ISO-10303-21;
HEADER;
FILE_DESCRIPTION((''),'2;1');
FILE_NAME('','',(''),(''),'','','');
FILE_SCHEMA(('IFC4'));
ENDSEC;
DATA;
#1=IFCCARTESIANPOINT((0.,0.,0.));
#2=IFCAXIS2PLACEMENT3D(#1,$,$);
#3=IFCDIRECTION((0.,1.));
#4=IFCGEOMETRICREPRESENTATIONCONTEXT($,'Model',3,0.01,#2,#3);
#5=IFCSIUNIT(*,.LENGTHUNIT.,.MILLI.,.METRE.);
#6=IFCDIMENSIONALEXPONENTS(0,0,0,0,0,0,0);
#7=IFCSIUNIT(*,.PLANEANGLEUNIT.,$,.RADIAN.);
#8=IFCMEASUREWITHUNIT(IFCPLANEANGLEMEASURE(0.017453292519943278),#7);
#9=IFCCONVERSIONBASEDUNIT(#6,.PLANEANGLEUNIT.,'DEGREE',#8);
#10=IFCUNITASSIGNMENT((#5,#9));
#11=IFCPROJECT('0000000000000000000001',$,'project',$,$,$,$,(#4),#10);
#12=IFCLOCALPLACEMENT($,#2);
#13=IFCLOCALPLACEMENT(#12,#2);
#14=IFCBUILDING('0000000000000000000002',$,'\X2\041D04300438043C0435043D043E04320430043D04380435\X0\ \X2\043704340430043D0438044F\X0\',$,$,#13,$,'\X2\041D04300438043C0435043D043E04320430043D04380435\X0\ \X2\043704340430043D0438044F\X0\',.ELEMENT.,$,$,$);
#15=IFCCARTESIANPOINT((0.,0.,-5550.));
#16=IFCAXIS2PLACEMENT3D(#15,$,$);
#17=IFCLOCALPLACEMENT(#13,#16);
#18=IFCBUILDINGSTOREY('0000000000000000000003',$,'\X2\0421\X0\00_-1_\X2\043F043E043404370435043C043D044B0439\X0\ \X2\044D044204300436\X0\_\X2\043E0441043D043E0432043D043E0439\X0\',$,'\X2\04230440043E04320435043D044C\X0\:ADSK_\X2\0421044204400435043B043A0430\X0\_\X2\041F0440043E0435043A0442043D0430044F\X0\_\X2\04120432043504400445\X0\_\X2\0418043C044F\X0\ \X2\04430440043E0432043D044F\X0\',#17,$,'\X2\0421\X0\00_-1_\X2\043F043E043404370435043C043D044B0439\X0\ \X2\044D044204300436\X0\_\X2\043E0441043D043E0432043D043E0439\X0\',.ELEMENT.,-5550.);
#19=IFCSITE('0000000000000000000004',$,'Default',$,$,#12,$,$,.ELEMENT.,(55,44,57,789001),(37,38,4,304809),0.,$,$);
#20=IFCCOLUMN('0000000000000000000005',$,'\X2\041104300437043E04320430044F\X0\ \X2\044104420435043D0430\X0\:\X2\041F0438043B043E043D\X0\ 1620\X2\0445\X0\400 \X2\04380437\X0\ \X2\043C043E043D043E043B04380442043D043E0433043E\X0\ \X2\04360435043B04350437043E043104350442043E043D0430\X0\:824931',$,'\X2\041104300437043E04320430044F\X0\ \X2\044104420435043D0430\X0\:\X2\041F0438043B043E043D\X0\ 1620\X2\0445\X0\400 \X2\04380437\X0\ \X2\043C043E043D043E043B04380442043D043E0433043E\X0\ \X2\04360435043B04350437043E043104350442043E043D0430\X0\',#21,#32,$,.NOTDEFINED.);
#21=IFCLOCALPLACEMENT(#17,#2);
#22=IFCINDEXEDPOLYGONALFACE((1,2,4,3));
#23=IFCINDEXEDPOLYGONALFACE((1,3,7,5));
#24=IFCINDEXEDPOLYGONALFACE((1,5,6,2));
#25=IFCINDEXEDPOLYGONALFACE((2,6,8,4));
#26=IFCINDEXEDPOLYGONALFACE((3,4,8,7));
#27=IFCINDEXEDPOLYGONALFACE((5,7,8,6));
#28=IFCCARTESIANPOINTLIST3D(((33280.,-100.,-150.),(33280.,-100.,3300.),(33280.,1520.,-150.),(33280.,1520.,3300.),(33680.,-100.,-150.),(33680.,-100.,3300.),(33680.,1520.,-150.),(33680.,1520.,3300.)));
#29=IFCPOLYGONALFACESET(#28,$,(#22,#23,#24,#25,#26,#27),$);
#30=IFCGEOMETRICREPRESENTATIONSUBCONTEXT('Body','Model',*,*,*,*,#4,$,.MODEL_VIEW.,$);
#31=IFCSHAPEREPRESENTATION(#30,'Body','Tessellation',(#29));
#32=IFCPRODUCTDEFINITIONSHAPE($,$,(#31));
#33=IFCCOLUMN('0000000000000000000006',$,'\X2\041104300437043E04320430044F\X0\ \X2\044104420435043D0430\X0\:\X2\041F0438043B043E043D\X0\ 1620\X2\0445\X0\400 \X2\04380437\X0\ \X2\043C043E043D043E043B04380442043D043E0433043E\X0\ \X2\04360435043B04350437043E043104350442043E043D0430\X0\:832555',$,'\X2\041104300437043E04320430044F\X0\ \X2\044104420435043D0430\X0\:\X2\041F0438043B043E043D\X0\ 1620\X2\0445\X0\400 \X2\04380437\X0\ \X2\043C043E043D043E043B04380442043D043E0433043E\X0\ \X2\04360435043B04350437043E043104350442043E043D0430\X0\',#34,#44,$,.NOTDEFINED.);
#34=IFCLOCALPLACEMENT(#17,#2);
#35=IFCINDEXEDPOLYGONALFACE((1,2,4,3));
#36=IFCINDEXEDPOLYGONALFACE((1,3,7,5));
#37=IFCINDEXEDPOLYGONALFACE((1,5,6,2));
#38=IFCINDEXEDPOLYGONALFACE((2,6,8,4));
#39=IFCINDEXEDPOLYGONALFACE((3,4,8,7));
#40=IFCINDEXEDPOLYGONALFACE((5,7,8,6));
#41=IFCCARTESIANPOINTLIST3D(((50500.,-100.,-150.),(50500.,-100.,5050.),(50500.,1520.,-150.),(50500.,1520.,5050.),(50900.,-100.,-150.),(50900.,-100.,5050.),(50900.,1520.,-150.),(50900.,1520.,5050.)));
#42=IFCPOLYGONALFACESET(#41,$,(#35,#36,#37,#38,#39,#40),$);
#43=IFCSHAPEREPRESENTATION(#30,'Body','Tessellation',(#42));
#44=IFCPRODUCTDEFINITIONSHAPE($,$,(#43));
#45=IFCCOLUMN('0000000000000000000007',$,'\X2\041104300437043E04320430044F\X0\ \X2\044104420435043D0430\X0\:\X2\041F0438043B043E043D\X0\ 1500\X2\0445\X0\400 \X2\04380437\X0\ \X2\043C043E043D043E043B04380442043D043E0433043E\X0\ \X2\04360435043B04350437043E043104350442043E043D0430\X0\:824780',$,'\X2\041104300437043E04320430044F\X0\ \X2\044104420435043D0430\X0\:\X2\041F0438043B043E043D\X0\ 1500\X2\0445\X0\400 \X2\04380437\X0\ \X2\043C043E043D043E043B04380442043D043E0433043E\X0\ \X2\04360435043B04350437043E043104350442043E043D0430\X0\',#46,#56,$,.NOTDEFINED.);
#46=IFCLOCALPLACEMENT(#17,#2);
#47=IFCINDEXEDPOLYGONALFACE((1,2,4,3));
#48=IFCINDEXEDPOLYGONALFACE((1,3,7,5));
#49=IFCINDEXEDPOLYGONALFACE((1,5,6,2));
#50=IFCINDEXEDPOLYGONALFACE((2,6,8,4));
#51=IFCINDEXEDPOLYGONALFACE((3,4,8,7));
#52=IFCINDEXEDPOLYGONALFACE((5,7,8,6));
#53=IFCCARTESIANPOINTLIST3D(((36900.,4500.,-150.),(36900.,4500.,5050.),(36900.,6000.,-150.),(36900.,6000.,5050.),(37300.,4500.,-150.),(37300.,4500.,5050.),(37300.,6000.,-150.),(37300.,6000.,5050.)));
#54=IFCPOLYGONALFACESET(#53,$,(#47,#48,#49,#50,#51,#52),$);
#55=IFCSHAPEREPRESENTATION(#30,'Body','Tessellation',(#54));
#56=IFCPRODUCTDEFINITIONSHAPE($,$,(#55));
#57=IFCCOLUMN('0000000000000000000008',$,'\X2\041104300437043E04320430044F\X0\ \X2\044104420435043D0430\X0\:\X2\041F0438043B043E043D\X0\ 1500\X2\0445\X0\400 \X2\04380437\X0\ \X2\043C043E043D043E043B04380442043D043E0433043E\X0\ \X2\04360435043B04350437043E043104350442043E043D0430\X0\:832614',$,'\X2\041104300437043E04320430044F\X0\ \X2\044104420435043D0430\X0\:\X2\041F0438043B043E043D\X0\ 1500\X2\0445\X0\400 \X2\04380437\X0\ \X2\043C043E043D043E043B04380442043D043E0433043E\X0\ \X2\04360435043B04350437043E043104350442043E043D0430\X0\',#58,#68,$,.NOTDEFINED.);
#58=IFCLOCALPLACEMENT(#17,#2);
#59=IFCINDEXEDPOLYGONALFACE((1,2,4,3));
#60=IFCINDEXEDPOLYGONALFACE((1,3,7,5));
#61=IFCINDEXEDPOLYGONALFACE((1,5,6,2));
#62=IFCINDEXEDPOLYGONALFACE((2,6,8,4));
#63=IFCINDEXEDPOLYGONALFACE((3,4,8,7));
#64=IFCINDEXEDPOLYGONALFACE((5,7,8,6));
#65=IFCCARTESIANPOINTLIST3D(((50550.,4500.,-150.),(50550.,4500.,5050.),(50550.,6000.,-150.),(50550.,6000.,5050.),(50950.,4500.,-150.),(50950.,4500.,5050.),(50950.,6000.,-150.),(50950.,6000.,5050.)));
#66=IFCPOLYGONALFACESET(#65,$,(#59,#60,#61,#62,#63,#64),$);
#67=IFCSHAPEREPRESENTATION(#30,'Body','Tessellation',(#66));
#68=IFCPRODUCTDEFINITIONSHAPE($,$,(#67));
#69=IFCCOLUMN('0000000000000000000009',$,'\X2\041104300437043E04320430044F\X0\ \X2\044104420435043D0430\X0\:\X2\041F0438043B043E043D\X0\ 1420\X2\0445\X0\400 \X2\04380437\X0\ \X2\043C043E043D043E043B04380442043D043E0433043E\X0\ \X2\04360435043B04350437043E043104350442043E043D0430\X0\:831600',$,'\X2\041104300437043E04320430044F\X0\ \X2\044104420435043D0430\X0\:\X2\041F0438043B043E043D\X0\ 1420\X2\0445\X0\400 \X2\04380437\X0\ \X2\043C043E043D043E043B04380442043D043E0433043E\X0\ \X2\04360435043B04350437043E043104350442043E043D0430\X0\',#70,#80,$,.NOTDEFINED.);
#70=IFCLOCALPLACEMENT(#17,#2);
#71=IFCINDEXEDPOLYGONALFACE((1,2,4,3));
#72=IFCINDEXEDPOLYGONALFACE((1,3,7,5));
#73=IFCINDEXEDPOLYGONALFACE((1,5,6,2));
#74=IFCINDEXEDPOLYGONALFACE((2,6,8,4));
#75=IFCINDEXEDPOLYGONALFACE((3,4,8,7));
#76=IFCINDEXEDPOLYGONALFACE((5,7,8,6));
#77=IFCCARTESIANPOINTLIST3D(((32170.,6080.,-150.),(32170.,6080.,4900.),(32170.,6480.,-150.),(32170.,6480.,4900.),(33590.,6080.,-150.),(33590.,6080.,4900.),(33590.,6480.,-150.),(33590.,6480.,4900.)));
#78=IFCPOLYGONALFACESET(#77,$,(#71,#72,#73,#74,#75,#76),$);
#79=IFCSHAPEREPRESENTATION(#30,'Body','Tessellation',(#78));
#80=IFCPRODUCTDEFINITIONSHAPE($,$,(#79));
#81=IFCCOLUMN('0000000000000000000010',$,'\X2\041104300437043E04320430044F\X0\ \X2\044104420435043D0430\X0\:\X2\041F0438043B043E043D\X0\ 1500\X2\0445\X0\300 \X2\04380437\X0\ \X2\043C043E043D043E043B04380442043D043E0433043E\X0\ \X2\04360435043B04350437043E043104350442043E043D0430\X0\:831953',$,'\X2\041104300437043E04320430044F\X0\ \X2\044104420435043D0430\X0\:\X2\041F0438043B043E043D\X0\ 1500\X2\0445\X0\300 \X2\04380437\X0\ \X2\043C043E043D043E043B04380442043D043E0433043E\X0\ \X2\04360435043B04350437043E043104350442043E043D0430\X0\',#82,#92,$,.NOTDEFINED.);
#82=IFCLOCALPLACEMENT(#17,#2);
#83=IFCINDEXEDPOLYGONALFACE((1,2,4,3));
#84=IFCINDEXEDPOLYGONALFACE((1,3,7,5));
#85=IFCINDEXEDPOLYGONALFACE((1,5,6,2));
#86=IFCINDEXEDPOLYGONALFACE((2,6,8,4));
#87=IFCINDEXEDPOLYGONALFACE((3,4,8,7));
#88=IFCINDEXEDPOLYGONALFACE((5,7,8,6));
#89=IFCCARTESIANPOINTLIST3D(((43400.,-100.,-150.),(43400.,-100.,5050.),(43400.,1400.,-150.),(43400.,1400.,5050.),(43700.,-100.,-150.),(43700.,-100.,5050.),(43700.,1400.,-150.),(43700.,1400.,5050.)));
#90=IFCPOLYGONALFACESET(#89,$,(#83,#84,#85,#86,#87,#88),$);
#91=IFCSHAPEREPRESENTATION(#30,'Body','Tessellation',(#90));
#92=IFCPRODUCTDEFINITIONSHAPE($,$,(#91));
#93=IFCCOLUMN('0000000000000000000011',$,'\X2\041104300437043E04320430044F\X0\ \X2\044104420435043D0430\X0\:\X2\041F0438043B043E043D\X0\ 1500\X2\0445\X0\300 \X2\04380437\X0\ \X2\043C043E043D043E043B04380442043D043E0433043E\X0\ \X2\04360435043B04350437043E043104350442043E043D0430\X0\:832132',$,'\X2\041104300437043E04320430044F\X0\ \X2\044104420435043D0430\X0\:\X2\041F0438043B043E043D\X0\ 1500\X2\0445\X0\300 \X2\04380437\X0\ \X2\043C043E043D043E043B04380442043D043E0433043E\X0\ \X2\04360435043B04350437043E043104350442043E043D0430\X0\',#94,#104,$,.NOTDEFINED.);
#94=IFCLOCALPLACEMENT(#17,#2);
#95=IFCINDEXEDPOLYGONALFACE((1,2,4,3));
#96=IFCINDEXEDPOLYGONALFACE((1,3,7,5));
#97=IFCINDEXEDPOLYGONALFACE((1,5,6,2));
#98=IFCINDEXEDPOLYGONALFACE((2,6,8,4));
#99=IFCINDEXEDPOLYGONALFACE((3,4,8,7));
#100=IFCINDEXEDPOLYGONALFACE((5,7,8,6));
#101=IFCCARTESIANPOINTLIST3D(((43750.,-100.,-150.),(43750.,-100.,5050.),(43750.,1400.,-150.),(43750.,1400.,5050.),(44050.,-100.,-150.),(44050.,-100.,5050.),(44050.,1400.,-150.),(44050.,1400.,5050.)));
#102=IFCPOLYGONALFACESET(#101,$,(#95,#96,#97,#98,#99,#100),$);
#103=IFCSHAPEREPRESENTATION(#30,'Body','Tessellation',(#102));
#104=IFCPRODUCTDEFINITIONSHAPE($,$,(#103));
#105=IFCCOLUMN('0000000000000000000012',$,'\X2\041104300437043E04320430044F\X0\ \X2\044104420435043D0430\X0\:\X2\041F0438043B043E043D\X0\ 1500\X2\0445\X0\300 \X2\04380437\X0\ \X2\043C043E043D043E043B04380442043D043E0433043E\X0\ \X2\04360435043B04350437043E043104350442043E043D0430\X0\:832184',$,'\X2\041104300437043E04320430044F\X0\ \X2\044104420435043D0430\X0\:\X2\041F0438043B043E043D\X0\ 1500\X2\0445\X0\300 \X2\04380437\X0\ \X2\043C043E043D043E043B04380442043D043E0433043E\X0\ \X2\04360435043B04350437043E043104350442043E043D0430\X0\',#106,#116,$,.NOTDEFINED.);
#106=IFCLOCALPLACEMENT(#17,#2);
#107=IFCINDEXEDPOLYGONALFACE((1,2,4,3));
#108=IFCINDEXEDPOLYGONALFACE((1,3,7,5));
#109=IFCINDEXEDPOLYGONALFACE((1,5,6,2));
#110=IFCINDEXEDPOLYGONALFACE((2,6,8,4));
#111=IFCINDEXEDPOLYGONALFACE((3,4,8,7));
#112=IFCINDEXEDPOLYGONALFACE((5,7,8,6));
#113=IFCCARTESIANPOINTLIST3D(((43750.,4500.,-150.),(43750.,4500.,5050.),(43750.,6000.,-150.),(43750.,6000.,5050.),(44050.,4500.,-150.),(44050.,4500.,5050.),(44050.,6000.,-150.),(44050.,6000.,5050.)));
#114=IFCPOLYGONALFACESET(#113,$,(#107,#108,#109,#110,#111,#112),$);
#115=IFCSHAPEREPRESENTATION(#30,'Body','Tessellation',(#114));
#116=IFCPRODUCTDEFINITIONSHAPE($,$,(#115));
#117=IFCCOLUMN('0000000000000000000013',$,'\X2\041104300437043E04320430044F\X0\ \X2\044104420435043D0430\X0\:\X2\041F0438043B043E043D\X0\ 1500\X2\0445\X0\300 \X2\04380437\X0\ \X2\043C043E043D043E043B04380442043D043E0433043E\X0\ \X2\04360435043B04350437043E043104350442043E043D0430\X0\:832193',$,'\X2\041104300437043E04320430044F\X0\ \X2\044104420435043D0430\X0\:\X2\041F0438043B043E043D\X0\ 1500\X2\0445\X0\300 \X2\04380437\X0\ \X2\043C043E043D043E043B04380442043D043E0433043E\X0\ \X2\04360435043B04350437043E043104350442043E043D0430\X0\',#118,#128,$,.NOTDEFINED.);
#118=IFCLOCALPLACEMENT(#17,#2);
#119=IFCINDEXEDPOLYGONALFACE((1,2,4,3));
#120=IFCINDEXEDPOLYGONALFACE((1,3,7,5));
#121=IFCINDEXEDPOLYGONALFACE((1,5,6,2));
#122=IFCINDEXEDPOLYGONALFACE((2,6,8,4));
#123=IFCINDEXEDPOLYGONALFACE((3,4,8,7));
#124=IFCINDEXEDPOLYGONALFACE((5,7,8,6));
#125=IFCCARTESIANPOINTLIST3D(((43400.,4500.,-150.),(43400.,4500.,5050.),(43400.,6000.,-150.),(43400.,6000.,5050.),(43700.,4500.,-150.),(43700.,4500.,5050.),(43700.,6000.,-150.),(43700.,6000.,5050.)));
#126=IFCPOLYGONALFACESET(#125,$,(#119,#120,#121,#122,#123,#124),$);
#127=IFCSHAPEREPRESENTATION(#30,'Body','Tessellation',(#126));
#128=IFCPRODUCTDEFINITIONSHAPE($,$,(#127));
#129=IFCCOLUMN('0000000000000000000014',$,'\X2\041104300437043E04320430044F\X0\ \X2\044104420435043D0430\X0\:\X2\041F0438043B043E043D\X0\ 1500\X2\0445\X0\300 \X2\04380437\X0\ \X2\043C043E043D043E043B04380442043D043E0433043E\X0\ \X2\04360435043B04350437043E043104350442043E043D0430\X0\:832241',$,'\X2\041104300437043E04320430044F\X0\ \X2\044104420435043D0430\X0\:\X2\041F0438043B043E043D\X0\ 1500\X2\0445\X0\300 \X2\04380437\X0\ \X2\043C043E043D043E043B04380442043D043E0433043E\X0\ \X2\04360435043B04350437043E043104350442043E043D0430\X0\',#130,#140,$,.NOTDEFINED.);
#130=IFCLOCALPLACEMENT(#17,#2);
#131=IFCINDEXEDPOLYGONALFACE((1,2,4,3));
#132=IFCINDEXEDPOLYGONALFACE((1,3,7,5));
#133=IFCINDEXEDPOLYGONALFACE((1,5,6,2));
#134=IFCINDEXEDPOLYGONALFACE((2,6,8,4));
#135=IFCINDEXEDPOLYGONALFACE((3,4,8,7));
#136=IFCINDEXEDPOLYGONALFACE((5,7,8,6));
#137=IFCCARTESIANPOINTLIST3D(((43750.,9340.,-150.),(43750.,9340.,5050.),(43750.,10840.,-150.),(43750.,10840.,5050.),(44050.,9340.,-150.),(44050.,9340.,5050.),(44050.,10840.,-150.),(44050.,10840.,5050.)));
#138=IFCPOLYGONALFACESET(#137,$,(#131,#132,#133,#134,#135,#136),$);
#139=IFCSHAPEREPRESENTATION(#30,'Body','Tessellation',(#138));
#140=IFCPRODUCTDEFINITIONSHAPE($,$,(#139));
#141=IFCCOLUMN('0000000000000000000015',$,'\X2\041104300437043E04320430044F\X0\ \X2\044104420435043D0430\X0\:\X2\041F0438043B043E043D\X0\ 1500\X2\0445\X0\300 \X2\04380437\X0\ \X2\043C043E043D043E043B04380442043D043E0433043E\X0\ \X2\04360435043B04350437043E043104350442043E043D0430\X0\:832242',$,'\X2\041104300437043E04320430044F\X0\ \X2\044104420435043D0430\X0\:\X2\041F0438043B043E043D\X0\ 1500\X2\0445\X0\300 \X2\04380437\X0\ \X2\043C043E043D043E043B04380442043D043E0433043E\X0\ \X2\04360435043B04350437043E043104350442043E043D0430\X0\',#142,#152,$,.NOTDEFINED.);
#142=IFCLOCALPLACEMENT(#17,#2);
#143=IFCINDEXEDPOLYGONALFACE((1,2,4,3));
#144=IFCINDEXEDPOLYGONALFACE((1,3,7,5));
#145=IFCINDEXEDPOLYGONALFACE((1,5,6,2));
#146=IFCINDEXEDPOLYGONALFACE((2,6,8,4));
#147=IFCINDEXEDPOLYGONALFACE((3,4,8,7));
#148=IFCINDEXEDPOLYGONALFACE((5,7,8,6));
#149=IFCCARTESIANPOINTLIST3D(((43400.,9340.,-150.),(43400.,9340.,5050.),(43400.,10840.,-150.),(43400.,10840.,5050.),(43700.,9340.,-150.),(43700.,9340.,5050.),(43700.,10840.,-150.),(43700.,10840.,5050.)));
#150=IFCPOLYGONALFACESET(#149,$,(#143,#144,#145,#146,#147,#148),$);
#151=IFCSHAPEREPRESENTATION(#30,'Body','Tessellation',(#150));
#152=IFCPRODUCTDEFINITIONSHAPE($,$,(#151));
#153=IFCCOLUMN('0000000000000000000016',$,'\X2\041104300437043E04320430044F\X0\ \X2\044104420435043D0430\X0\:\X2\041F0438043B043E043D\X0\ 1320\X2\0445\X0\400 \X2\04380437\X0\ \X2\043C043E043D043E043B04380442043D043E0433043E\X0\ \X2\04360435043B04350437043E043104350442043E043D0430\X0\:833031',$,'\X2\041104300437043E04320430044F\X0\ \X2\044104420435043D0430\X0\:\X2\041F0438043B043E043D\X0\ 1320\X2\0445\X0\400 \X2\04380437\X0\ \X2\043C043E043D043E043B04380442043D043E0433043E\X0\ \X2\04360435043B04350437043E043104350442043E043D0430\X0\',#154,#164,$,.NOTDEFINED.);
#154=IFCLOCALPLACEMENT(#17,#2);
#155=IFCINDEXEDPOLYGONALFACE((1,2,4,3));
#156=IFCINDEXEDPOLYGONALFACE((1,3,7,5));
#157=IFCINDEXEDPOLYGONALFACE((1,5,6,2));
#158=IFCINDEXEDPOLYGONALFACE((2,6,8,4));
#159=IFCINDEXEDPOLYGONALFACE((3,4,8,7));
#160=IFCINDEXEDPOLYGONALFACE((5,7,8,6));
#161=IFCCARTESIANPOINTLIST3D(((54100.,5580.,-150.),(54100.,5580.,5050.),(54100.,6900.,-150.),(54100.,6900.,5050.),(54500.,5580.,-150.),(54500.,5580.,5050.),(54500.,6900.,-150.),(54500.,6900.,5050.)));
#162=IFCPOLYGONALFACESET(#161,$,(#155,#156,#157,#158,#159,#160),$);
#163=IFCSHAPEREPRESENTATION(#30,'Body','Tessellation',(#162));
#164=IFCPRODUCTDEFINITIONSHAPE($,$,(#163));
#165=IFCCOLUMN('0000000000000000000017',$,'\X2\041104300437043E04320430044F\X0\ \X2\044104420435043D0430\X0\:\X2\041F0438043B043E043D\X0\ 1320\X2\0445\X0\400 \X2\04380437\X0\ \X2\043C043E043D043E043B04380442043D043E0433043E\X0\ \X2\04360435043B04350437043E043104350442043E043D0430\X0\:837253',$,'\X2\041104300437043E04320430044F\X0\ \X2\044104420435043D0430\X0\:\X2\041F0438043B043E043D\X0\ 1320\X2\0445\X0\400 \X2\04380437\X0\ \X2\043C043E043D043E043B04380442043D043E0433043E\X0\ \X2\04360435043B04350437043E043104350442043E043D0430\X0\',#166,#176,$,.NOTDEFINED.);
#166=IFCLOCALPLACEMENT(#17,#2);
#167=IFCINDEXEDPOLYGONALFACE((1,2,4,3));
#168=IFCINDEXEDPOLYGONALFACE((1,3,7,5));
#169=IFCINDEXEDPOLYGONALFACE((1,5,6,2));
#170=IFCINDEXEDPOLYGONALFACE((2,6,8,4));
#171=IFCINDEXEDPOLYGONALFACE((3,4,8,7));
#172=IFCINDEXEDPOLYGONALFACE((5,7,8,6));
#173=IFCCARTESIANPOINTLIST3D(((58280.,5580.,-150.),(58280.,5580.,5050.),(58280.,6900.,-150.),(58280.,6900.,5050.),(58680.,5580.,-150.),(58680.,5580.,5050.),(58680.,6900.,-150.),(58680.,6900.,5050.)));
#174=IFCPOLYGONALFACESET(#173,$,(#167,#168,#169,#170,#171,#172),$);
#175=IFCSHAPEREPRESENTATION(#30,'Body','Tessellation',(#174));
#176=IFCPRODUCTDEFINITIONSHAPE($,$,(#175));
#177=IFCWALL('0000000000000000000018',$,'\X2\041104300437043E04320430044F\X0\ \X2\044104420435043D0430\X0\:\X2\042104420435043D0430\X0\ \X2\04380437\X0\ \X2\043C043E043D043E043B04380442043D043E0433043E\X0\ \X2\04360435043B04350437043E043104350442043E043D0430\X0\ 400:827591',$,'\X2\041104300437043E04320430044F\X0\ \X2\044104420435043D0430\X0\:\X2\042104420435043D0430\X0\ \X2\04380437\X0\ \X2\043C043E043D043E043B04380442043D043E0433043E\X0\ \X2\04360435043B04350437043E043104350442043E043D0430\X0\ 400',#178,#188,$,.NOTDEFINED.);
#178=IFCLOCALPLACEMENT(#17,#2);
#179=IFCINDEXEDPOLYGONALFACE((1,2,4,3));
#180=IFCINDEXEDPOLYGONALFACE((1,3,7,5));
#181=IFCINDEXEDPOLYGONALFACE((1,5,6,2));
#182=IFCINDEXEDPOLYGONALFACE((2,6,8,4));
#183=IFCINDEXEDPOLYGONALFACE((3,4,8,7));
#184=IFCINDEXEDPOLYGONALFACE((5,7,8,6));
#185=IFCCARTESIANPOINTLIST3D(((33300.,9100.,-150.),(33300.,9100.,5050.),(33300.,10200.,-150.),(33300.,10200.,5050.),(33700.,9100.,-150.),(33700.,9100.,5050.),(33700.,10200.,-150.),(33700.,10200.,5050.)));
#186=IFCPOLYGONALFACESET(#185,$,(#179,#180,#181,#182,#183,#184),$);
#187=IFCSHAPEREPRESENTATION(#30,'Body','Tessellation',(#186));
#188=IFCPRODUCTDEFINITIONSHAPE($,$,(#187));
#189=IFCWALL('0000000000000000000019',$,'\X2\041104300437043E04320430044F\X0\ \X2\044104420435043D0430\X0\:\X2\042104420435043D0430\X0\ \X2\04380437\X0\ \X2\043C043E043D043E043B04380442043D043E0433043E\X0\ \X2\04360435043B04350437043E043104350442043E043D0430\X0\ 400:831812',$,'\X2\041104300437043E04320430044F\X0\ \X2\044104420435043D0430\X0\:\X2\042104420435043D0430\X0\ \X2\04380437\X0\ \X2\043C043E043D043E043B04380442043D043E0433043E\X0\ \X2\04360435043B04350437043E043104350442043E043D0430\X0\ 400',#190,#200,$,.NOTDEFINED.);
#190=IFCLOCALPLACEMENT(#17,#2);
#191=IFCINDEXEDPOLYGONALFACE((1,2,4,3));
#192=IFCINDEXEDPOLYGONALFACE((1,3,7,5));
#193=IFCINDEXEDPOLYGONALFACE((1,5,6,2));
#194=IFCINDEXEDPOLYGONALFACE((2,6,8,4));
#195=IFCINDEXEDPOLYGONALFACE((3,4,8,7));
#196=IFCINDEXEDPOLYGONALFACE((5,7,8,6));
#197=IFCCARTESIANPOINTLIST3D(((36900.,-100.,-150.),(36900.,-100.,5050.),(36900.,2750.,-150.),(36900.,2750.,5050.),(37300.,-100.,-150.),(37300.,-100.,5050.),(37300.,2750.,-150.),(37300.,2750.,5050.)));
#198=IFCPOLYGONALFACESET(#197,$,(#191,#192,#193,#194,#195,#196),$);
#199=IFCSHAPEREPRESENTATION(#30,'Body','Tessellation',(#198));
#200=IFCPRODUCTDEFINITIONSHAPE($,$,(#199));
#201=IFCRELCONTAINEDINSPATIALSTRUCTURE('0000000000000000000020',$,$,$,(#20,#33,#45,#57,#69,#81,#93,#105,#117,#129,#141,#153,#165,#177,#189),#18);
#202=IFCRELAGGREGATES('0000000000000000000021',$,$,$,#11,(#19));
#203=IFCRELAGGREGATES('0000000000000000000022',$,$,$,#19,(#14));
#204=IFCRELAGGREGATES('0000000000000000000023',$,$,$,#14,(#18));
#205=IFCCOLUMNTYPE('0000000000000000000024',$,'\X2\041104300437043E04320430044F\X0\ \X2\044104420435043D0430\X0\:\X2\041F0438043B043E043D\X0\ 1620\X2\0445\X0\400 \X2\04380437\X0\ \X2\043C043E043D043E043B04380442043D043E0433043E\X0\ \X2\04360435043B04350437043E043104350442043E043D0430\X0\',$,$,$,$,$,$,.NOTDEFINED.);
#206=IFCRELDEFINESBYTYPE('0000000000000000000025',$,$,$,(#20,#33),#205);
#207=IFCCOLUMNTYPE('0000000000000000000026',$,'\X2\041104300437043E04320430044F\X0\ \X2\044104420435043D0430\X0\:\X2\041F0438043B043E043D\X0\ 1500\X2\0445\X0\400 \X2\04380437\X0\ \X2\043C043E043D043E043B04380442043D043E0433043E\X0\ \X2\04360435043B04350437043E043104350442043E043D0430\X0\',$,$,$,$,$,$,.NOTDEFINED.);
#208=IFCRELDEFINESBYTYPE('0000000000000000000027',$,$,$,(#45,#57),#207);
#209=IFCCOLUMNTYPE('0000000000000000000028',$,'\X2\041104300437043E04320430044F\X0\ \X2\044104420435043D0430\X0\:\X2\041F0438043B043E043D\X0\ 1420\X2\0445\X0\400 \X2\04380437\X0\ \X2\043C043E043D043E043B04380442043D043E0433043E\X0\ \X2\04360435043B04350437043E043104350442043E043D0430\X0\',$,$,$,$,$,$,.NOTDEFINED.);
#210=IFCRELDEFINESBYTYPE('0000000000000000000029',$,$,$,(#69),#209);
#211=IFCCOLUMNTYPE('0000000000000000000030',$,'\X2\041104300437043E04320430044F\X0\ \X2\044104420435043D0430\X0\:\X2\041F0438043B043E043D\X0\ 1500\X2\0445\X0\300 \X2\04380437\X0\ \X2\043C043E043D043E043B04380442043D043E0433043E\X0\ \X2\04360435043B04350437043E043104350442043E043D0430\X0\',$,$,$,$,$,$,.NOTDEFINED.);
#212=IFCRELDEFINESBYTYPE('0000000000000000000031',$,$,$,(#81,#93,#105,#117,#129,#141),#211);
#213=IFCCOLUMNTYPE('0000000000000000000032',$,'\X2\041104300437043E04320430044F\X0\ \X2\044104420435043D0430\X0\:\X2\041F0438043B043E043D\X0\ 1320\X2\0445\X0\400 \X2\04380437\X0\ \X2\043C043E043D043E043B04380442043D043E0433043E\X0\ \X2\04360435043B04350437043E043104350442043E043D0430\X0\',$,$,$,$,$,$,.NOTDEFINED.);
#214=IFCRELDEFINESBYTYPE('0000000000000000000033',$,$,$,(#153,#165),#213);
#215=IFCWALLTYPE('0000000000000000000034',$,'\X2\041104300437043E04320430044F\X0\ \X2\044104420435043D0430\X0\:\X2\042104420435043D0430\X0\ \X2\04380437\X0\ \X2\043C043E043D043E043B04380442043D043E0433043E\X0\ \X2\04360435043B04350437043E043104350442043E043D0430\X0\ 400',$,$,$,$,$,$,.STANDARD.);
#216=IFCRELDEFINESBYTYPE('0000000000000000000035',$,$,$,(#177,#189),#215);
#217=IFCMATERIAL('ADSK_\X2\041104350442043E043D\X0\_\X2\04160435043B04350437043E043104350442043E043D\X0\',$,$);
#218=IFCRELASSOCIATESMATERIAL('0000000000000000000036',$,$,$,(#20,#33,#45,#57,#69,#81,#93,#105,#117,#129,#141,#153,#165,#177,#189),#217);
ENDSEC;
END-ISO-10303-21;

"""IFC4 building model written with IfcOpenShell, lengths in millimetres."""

from ifc_helpers import new_model, entity, si_unit, converted_unit, direction, frame, origin, place, context, subcontext, project, spatial, indexed_curve, outline, extrude, material, type_object, element, save


model = new_model("IFC4")

# Units and contexts
model_context = context("Model", 3, precision=0.01, world=origin(), true_north=direction((0.0, 1.0)))
body_context = subcontext(model_context, "Body", "Model", "MODEL_VIEW")
ifc_project = project(units=[si_unit("LENGTHUNIT", "METRE", prefix="MILLI"), converted_unit("PLANEANGLEUNIT", "DEGREE", entity("IfcPlaneAngleMeasure", 0.017453292519943278), si_unit("PLANEANGLEUNIT", "RADIAN"), dimensions=[0, 0, 0, 0, 0, 0, 0])], contexts=[model_context])

# Site, building, storey
site_placement = place(None, origin())
site = spatial("IfcSite", under=ifc_project, at=site_placement, Name="Default", CompositionType="ELEMENT", RefLatitude=(55, 44, 57, 789001), RefLongitude=(37, 38, 4, 304809), RefElevation=0.0)
building_placement = place(site_placement, origin())
building = spatial("IfcBuilding", under=site, at=building_placement, Name="Наименование здания", LongName="Наименование здания", CompositionType="ELEMENT")
storey_placement = place(building_placement, frame((0.0, 0.0, -5550.0)))
storey = spatial("IfcBuildingStorey", under=building, at=storey_placement, Name="С00_-1_подземный этаж_основной", ObjectType="Уровень:ADSK_Стрелка_Проектная_Вверх_Имя уровня", LongName="С00_-1_подземный этаж_основной", CompositionType="ELEMENT", Elevation=-5550.0)

# Columns
ifc_material_1 = material(Name="ADSK_Бетон_Железобетон")
column_type_1 = type_object("IfcColumnType", Name="Базовая стена:Пилон 1620х400 из монолитного железобетона", PredefinedType="NOTDEFINED")
column_1_placement = place(storey_placement, frame((33480.0, -100.0, -150.0), z_axis=(0.0, 0.0, 1.0), x_axis=(0.0, 1.0, 0.0)))
element("IfcColumn", 1, at=column_1_placement, inside=storey, type_object=column_type_1, material=ifc_material_1, Name="Базовая стена:Пилон 1620х400 из монолитного железобетона:824931", ObjectType="Базовая стена:Пилон 1620х400 из монолитного железобетона", PredefinedType="NOTDEFINED", context=body_context, shape_type="SweptSolid", body=[
    extrude(outline(indexed_curve([(1620.0, 200.0), (0.0, 200.0), (0.0, -200.0), (1620.0, -200.0), (1620.0, 200.0)], self_intersect=False)), origin(), (0.0, 0.0, 1.0), 3450.0),
])
column_2_placement = place(storey_placement, frame((50700.0, -100.0, -150.0), z_axis=(0.0, 0.0, 1.0), x_axis=(0.0, 1.0, 0.0)))
element("IfcColumn", 2, at=column_2_placement, inside=storey, type_object=column_type_1, material=ifc_material_1, Name="Базовая стена:Пилон 1620х400 из монолитного железобетона:832555", ObjectType="Базовая стена:Пилон 1620х400 из монолитного железобетона", PredefinedType="NOTDEFINED", context=body_context, shape_type="SweptSolid", body=[
    extrude(outline(indexed_curve([(1620.0, 200.0), (0.0, 200.0), (0.0, -200.0), (1620.0, -200.0), (1620.0, 200.0)], self_intersect=False)), origin(), (0.0, 0.0, 1.0), 5200.0),
])
column_type_2 = type_object("IfcColumnType", Name="Базовая стена:Пилон 1500х400 из монолитного железобетона", PredefinedType="NOTDEFINED")
column_3_placement = place(storey_placement, frame((37100.0, 4500.0, -150.0), z_axis=(0.0, 0.0, 1.0), x_axis=(0.0, 1.0, 0.0)))
element("IfcColumn", 3, at=column_3_placement, inside=storey, type_object=column_type_2, material=ifc_material_1, Name="Базовая стена:Пилон 1500х400 из монолитного железобетона:824780", ObjectType="Базовая стена:Пилон 1500х400 из монолитного железобетона", PredefinedType="NOTDEFINED", context=body_context, shape_type="SweptSolid", body=[
    extrude(outline(indexed_curve([(1500.0, 200.0), (0.0, 200.0), (0.0, -200.0), (1500.0, -200.0), (1500.0, 200.0)], self_intersect=False)), origin(), (0.0, 0.0, 1.0), 5200.0),
])
column_4_placement = place(storey_placement, frame((50750.0, 4500.0, -150.0), z_axis=(0.0, 0.0, 1.0), x_axis=(0.0, 1.0, 0.0)))
element("IfcColumn", 4, at=column_4_placement, inside=storey, type_object=column_type_2, material=ifc_material_1, Name="Базовая стена:Пилон 1500х400 из монолитного железобетона:832614", ObjectType="Базовая стена:Пилон 1500х400 из монолитного железобетона", PredefinedType="NOTDEFINED", context=body_context, shape_type="SweptSolid", body=[
    extrude(outline(indexed_curve([(1500.0, 200.0), (0.0, 200.0), (0.0, -200.0), (1500.0, -200.0), (1500.0, 200.0)], self_intersect=False)), origin(), (0.0, 0.0, 1.0), 5200.0),
])
column_type_3 = type_object("IfcColumnType", Name="Базовая стена:Пилон 1420х400 из монолитного железобетона", PredefinedType="NOTDEFINED")
column_5_placement = place(storey_placement, frame((32170.0, 6280.0, -150.0)))
element("IfcColumn", 5, at=column_5_placement, inside=storey, type_object=column_type_3, material=ifc_material_1, Name="Базовая стена:Пилон 1420х400 из монолитного железобетона:831600", ObjectType="Базовая стена:Пилон 1420х400 из монолитного железобетона", PredefinedType="NOTDEFINED", context=body_context, shape_type="SweptSolid", body=[
    extrude(outline(indexed_curve([(1420.0, 200.0), (0.0, 200.0), (0.0, -200.0), (1420.0, -200.0), (1420.0, 200.0)], self_intersect=False)), origin(), (0.0, 0.0, 1.0), 5050.0),
])
column_type_4 = type_object("IfcColumnType", Name="Базовая стена:Пилон 1500х300 из монолитного железобетона", PredefinedType="NOTDEFINED")
for number, where, z_axis, x_axis, name in (
    (6, (43550.0, -100.0, -150.0), (0.0, 0.0, 1.0), (0.0, 1.0, 0.0), "Базовая стена:Пилон 1500х300 из монолитного железобетона:831953"),
    (7, (43900.0, -100.0, -150.0), (0.0, 0.0, 1.0), (0.0, 1.0, 0.0), "Базовая стена:Пилон 1500х300 из монолитного железобетона:832132"),
    (8, (43900.0, 4500.0, -150.0), (0.0, 0.0, 1.0), (0.0, 1.0, 0.0), "Базовая стена:Пилон 1500х300 из монолитного железобетона:832184"),
    (9, (43550.0, 4500.0, -150.0), (0.0, 0.0, 1.0), (0.0, 1.0, 0.0), "Базовая стена:Пилон 1500х300 из монолитного железобетона:832193"),
    (10, (43900.0, 9340.0, -150.0), (0.0, 0.0, 1.0), (0.0, 1.0, 0.0), "Базовая стена:Пилон 1500х300 из монолитного железобетона:832241"),
):
    element("IfcColumn", number, at=place(storey_placement, frame(where, z_axis=z_axis, x_axis=x_axis)), inside=storey, type_object=column_type_4, material=ifc_material_1, Name=name, ObjectType="Базовая стена:Пилон 1500х300 из монолитного железобетона", PredefinedType="NOTDEFINED", context=body_context, shape_type="SweptSolid", body=[
        extrude(outline(indexed_curve([(1500.0, 150.0), (0.0, 150.0), (0.0, -150.0), (1500.0, -150.0), (1500.0, 150.0)], self_intersect=False)), origin(), (0.0, 0.0, 1.0), 5200.0),
    ])
column_6_placement = place(storey_placement, frame((43550.0, 9340.0, -150.0), z_axis=(0.0, 0.0, 1.0), x_axis=(0.0, 1.0, 0.0)))
element("IfcColumn", 11, at=column_6_placement, inside=storey, type_object=column_type_4, material=ifc_material_1, Name="Базовая стена:Пилон 1500х300 из монолитного железобетона:832242", ObjectType="Базовая стена:Пилон 1500х300 из монолитного железобетона", PredefinedType="NOTDEFINED", context=body_context, shape_type="SweptSolid", body=[
    extrude(outline(indexed_curve([(1500.0, 150.0), (0.0, 150.0), (0.0, -150.0), (1500.0, -150.0), (1500.0, 150.0)], self_intersect=False)), origin(), (0.0, 0.0, 1.0), 5200.0),
])
column_type_5 = type_object("IfcColumnType", Name="Базовая стена:Пилон 1320х400 из монолитного железобетона", PredefinedType="NOTDEFINED")
for number, where, z_axis, x_axis, name in (
    (12, (54300.0, 5580.0, -150.0), (0.0, 0.0, 1.0), (0.0, 1.0, 0.0), "Базовая стена:Пилон 1320х400 из монолитного железобетона:833031"),
    (13, (58480.0, 5580.0, -150.0), (0.0, 0.0, 1.0), (0.0, 1.0, 0.0), "Базовая стена:Пилон 1320х400 из монолитного железобетона:837253"),
):
    element("IfcColumn", number, at=place(storey_placement, frame(where, z_axis=z_axis, x_axis=x_axis)), inside=storey, type_object=column_type_5, material=ifc_material_1, Name=name, ObjectType="Базовая стена:Пилон 1320х400 из монолитного железобетона", PredefinedType="NOTDEFINED", context=body_context, shape_type="SweptSolid", body=[
        extrude(outline(indexed_curve([(1320.0, 200.0), (0.0, 200.0), (0.0, -200.0), (1320.0, -200.0), (1320.0, 200.0)], self_intersect=False)), origin(), (0.0, 0.0, 1.0), 5200.0),
    ])

# Walls
wall_type_1 = type_object("IfcWallType", Name="Базовая стена:Стена из монолитного железобетона 400", PredefinedType="STANDARD")
wall_1_placement = place(storey_placement, frame((33500.0, 9100.0, -150.0), z_axis=(0.0, 0.0, 1.0), x_axis=(0.0, 1.0, 0.0)))
element("IfcWall", 14, at=wall_1_placement, inside=storey, type_object=wall_type_1, material=ifc_material_1, Name="Базовая стена:Стена из монолитного железобетона 400:827591", ObjectType="Базовая стена:Стена из монолитного железобетона 400", PredefinedType="NOTDEFINED", context=body_context, shape_type="SweptSolid", body=[
    extrude(outline(indexed_curve([(1100.0, 200.0), (0.0, 200.0), (0.0, -200.0), (1100.0, -200.0), (1100.0, 200.0)], self_intersect=False)), origin(), (0.0, 0.0, 1.0), 5200.0),
])
wall_2_placement = place(storey_placement, frame((37100.0, -100.0, -150.0), z_axis=(0.0, 0.0, 1.0), x_axis=(0.0, 1.0, 0.0)))
element("IfcWall", 15, at=wall_2_placement, inside=storey, type_object=wall_type_1, material=ifc_material_1, Name="Базовая стена:Стена из монолитного железобетона 400:831812", ObjectType="Базовая стена:Стена из монолитного железобетона 400", PredefinedType="NOTDEFINED", context=body_context, shape_type="SweptSolid", body=[
    extrude(outline(indexed_curve([(2850.0, 200.0), (0.0, 200.0), (0.0, -200.0), (2850.0, -200.0), (2850.0, 200.0)], self_intersect=False)), origin(), (0.0, 0.0, 1.0), 5200.0),
])

save(model, "model.ifc")
